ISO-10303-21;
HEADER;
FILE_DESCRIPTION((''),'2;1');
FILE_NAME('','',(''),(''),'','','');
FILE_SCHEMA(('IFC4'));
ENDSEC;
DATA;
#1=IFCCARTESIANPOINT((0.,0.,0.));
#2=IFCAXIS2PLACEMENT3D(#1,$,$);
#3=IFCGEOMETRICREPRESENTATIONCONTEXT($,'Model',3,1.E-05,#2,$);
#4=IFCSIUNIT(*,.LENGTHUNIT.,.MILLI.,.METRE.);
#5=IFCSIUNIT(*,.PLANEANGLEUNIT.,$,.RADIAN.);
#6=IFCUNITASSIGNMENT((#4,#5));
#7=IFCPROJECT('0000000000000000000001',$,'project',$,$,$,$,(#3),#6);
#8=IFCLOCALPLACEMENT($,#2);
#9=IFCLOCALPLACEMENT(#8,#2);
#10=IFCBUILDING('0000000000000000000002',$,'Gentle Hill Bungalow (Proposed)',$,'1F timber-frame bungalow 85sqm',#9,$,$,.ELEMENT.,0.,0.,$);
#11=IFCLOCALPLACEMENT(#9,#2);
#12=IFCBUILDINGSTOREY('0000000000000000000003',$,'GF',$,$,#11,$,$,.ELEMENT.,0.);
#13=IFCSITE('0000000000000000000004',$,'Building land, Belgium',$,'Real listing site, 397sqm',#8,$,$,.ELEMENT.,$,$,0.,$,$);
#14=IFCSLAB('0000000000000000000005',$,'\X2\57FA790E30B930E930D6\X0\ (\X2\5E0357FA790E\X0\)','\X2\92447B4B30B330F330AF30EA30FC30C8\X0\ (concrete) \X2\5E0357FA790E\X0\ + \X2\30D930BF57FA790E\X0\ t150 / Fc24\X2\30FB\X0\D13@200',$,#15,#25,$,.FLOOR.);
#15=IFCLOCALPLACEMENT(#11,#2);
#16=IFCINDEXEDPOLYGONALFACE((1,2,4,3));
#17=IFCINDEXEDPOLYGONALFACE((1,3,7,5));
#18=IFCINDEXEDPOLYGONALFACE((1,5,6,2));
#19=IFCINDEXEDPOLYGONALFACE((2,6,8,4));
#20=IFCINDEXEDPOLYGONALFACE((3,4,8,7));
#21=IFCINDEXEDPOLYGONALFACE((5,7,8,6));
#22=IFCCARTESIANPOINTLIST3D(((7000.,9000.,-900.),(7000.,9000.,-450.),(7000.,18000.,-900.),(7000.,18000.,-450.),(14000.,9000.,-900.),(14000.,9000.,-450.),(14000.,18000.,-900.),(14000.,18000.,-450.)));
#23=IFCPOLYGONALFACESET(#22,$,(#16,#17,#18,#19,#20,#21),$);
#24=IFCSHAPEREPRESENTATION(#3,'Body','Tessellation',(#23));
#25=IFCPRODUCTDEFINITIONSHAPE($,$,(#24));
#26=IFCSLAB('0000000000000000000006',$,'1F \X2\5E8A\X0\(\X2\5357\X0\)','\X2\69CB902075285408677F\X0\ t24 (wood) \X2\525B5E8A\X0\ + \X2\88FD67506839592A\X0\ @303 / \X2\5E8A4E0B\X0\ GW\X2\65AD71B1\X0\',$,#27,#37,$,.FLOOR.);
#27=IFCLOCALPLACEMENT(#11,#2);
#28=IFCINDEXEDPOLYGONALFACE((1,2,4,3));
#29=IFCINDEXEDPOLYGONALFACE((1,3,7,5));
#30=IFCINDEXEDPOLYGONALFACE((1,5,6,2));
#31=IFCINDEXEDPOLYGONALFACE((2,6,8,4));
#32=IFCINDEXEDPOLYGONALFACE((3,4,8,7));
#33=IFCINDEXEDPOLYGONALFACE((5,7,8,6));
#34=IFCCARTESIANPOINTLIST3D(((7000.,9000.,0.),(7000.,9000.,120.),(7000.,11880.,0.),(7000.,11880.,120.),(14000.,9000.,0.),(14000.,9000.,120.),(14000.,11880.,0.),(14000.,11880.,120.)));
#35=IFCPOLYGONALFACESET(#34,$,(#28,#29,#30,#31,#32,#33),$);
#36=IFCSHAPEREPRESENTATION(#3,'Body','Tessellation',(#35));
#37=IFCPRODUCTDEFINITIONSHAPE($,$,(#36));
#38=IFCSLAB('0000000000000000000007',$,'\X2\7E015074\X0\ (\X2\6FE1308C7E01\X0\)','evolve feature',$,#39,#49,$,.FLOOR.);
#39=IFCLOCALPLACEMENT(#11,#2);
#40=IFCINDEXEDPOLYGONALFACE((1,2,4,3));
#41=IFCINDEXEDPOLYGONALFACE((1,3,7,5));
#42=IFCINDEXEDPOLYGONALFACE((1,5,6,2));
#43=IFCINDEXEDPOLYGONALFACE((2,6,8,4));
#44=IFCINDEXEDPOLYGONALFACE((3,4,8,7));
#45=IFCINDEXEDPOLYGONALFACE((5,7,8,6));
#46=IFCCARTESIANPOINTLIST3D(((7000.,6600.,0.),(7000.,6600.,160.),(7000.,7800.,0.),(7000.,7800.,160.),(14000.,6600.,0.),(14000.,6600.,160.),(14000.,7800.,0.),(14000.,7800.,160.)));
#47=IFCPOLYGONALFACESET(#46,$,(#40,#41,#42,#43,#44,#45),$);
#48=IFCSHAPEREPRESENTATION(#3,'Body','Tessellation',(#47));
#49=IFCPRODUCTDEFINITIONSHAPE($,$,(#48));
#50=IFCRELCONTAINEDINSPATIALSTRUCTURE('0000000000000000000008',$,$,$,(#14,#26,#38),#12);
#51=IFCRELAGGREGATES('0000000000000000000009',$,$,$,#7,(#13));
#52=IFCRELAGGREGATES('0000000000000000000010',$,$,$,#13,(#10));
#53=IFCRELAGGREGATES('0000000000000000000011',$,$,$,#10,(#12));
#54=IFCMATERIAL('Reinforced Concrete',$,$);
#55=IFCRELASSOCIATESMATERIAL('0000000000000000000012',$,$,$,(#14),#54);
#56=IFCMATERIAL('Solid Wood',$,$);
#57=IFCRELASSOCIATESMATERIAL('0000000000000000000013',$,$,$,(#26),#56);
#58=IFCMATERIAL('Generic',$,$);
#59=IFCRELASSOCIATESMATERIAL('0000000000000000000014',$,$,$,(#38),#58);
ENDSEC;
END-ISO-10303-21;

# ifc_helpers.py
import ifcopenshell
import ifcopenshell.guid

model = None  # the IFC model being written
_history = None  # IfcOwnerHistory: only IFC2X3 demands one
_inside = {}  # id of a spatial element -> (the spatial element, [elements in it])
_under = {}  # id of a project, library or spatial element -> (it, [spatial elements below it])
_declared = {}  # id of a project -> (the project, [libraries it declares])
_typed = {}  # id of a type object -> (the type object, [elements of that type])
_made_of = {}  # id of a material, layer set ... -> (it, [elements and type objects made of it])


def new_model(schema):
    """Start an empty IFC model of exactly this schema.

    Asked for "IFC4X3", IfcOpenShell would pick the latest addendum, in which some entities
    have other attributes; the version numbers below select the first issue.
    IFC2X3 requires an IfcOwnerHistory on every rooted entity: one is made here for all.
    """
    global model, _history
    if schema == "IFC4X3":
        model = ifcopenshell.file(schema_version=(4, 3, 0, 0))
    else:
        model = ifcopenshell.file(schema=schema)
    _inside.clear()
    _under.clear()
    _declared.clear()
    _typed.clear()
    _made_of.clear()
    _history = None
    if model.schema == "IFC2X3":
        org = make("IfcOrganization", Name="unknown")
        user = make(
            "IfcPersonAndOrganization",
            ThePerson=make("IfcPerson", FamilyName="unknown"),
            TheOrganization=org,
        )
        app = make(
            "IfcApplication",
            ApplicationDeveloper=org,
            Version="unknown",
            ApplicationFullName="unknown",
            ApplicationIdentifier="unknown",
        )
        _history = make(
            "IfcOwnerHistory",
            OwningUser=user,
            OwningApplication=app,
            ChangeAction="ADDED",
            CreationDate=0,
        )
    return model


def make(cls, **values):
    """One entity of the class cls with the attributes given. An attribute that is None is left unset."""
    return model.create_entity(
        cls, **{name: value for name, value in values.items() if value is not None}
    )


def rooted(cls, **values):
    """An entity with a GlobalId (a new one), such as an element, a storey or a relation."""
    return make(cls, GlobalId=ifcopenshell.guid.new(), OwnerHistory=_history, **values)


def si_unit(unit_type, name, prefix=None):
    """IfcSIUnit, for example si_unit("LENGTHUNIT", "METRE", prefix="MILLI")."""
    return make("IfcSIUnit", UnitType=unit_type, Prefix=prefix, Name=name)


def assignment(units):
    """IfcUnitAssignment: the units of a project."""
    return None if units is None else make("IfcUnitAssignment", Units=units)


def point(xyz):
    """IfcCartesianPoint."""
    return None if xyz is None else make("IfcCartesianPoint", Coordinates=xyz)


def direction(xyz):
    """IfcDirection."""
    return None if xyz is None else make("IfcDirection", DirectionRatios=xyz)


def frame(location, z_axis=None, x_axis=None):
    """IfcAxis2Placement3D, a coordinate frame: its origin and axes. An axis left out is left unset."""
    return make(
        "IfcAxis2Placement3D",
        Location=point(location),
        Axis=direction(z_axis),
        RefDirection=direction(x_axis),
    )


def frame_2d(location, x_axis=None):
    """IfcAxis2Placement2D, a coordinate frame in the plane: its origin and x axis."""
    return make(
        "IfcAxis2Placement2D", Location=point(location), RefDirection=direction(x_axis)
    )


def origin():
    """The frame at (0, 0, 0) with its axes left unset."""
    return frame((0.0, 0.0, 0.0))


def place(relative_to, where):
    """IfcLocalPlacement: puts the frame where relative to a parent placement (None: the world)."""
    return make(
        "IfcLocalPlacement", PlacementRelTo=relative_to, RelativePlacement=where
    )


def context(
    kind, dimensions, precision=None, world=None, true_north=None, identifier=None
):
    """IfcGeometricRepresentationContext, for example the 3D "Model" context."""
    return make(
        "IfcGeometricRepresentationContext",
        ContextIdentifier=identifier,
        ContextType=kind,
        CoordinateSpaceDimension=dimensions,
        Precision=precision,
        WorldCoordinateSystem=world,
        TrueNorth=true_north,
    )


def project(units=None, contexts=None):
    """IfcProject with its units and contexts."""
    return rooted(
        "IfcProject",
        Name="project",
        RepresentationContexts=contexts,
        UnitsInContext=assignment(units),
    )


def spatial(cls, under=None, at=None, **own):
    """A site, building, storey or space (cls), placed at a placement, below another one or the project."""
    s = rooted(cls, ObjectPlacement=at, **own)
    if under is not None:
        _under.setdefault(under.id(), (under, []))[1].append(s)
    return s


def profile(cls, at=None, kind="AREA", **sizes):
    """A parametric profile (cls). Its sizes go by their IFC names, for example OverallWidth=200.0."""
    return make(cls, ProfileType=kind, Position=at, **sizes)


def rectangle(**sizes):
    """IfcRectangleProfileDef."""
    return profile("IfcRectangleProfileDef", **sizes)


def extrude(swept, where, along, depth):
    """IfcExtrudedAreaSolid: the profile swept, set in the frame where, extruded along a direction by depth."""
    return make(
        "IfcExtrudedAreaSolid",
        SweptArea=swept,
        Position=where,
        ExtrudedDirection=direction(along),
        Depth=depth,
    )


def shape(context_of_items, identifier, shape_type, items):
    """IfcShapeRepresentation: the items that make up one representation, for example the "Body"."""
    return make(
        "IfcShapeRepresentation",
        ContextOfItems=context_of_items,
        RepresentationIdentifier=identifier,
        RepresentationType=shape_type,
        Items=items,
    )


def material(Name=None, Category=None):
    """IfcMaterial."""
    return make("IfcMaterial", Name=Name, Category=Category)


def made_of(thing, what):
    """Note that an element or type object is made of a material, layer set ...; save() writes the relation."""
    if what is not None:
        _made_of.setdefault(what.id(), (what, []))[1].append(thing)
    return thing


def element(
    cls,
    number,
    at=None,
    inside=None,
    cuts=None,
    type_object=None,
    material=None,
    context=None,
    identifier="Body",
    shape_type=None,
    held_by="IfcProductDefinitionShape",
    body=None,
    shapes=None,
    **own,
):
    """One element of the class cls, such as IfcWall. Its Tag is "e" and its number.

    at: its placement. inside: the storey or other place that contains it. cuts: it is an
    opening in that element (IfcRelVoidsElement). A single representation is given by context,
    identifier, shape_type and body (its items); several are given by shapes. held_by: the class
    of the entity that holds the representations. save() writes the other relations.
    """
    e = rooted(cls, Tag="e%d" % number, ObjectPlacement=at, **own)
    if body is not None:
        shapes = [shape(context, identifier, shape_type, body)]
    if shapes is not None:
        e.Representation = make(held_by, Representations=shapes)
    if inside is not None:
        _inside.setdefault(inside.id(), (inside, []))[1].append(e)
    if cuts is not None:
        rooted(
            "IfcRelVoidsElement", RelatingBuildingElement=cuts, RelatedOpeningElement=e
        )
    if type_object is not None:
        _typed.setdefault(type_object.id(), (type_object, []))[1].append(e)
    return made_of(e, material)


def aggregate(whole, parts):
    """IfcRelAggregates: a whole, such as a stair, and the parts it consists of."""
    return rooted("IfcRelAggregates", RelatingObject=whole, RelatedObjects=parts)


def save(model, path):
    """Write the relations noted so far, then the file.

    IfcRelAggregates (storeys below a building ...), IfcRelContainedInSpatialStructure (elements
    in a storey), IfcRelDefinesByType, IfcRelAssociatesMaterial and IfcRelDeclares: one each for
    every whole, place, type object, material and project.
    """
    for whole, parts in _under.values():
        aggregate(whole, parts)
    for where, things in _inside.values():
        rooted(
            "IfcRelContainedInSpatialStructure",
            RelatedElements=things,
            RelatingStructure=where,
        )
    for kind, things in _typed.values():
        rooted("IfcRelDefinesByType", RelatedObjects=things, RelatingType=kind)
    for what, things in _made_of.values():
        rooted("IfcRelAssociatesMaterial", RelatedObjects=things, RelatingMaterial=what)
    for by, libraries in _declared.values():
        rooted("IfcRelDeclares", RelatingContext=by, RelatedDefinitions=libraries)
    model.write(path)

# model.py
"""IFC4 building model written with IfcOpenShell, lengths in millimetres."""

from ifc_helpers import new_model, si_unit, frame, frame_2d, origin, place, context, project, spatial, rectangle, extrude, material, element, save


model = new_model("IFC4")

# Units and contexts
model_context = context("Model", 3, precision=1e-05, world=origin())
ifc_project = project(units=[si_unit("LENGTHUNIT", "METRE", prefix="MILLI"), si_unit("PLANEANGLEUNIT", "RADIAN")], contexts=[model_context])

# Site, building, storey
site_placement = place(None, origin())
site = spatial("IfcSite", under=ifc_project, at=site_placement, Name="Building land, Belgium", ObjectType="Real listing site, 397sqm", CompositionType="ELEMENT", RefElevation=0.0)
building_placement = place(site_placement, origin())
building = spatial("IfcBuilding", under=site, at=building_placement, Name="Gentle Hill Bungalow (Proposed)", ObjectType="1F timber-frame bungalow 85sqm", CompositionType="ELEMENT", ElevationOfRefHeight=0.0, ElevationOfTerrain=0.0)
storey_placement = place(building_placement, origin())
storey = spatial("IfcBuildingStorey", under=building, at=storey_placement, Name="GF", CompositionType="ELEMENT", Elevation=0.0)

# Slabs
ifc_material_1 = material(Name="Reinforced Concrete")
slab_1_placement = place(storey_placement, frame((3500.0, 4500.0, -450.0)))
element("IfcSlab", 1, at=slab_1_placement, inside=storey, material=ifc_material_1, Name="基礎スラブ (布基礎)", Description="鉄筋コンクリート (concrete) 布基礎 + ベタ基礎 t150 / Fc24・D13@200", PredefinedType="FLOOR", context=model_context, shape_type="SweptSolid", body=[
    extrude(rectangle(XDim=7000.0, YDim=9000.0, at=frame_2d((3500.0, 4500.0))), frame((3500.0, 4500.0, -450.0)), (0.0, 0.0, 1.0), 450.0),
])
ifc_material_2 = material(Name="Solid Wood")
slab_2_placement = place(storey_placement, frame((3500.0, 4500.0, 0.0)))
element("IfcSlab", 2, at=slab_2_placement, inside=storey, material=ifc_material_2, Name="1F 床(南)", Description="構造用合板 t24 (wood) 剛床 + 製材根太 @303 / 床下 GW断熱", PredefinedType="FLOOR", context=model_context, shape_type="SweptSolid", body=[
    extrude(rectangle(XDim=7000.0, YDim=2880.0, at=frame_2d((3500.0, 1440.0))), frame((3500.0, 4500.0, 0.0)), (0.0, 0.0, 1.0), 120.0),
])
ifc_material_3 = material(Name="Generic")
slab_3_placement = place(storey_placement, frame((3500.0, 3300.0, 0.0)))
element("IfcSlab", 3, at=slab_3_placement, inside=storey, material=ifc_material_3, Name="縁側 (濡れ縁)", Description="evolve feature", PredefinedType="FLOOR", context=model_context, shape_type="SweptSolid", body=[
    extrude(rectangle(XDim=7000.0, YDim=1200.0, at=frame_2d((3500.0, 600.0))), frame((3500.0, 3300.0, 0.0)), (0.0, 0.0, 1.0), 160.0),
])

save(model, "model.ifc")
